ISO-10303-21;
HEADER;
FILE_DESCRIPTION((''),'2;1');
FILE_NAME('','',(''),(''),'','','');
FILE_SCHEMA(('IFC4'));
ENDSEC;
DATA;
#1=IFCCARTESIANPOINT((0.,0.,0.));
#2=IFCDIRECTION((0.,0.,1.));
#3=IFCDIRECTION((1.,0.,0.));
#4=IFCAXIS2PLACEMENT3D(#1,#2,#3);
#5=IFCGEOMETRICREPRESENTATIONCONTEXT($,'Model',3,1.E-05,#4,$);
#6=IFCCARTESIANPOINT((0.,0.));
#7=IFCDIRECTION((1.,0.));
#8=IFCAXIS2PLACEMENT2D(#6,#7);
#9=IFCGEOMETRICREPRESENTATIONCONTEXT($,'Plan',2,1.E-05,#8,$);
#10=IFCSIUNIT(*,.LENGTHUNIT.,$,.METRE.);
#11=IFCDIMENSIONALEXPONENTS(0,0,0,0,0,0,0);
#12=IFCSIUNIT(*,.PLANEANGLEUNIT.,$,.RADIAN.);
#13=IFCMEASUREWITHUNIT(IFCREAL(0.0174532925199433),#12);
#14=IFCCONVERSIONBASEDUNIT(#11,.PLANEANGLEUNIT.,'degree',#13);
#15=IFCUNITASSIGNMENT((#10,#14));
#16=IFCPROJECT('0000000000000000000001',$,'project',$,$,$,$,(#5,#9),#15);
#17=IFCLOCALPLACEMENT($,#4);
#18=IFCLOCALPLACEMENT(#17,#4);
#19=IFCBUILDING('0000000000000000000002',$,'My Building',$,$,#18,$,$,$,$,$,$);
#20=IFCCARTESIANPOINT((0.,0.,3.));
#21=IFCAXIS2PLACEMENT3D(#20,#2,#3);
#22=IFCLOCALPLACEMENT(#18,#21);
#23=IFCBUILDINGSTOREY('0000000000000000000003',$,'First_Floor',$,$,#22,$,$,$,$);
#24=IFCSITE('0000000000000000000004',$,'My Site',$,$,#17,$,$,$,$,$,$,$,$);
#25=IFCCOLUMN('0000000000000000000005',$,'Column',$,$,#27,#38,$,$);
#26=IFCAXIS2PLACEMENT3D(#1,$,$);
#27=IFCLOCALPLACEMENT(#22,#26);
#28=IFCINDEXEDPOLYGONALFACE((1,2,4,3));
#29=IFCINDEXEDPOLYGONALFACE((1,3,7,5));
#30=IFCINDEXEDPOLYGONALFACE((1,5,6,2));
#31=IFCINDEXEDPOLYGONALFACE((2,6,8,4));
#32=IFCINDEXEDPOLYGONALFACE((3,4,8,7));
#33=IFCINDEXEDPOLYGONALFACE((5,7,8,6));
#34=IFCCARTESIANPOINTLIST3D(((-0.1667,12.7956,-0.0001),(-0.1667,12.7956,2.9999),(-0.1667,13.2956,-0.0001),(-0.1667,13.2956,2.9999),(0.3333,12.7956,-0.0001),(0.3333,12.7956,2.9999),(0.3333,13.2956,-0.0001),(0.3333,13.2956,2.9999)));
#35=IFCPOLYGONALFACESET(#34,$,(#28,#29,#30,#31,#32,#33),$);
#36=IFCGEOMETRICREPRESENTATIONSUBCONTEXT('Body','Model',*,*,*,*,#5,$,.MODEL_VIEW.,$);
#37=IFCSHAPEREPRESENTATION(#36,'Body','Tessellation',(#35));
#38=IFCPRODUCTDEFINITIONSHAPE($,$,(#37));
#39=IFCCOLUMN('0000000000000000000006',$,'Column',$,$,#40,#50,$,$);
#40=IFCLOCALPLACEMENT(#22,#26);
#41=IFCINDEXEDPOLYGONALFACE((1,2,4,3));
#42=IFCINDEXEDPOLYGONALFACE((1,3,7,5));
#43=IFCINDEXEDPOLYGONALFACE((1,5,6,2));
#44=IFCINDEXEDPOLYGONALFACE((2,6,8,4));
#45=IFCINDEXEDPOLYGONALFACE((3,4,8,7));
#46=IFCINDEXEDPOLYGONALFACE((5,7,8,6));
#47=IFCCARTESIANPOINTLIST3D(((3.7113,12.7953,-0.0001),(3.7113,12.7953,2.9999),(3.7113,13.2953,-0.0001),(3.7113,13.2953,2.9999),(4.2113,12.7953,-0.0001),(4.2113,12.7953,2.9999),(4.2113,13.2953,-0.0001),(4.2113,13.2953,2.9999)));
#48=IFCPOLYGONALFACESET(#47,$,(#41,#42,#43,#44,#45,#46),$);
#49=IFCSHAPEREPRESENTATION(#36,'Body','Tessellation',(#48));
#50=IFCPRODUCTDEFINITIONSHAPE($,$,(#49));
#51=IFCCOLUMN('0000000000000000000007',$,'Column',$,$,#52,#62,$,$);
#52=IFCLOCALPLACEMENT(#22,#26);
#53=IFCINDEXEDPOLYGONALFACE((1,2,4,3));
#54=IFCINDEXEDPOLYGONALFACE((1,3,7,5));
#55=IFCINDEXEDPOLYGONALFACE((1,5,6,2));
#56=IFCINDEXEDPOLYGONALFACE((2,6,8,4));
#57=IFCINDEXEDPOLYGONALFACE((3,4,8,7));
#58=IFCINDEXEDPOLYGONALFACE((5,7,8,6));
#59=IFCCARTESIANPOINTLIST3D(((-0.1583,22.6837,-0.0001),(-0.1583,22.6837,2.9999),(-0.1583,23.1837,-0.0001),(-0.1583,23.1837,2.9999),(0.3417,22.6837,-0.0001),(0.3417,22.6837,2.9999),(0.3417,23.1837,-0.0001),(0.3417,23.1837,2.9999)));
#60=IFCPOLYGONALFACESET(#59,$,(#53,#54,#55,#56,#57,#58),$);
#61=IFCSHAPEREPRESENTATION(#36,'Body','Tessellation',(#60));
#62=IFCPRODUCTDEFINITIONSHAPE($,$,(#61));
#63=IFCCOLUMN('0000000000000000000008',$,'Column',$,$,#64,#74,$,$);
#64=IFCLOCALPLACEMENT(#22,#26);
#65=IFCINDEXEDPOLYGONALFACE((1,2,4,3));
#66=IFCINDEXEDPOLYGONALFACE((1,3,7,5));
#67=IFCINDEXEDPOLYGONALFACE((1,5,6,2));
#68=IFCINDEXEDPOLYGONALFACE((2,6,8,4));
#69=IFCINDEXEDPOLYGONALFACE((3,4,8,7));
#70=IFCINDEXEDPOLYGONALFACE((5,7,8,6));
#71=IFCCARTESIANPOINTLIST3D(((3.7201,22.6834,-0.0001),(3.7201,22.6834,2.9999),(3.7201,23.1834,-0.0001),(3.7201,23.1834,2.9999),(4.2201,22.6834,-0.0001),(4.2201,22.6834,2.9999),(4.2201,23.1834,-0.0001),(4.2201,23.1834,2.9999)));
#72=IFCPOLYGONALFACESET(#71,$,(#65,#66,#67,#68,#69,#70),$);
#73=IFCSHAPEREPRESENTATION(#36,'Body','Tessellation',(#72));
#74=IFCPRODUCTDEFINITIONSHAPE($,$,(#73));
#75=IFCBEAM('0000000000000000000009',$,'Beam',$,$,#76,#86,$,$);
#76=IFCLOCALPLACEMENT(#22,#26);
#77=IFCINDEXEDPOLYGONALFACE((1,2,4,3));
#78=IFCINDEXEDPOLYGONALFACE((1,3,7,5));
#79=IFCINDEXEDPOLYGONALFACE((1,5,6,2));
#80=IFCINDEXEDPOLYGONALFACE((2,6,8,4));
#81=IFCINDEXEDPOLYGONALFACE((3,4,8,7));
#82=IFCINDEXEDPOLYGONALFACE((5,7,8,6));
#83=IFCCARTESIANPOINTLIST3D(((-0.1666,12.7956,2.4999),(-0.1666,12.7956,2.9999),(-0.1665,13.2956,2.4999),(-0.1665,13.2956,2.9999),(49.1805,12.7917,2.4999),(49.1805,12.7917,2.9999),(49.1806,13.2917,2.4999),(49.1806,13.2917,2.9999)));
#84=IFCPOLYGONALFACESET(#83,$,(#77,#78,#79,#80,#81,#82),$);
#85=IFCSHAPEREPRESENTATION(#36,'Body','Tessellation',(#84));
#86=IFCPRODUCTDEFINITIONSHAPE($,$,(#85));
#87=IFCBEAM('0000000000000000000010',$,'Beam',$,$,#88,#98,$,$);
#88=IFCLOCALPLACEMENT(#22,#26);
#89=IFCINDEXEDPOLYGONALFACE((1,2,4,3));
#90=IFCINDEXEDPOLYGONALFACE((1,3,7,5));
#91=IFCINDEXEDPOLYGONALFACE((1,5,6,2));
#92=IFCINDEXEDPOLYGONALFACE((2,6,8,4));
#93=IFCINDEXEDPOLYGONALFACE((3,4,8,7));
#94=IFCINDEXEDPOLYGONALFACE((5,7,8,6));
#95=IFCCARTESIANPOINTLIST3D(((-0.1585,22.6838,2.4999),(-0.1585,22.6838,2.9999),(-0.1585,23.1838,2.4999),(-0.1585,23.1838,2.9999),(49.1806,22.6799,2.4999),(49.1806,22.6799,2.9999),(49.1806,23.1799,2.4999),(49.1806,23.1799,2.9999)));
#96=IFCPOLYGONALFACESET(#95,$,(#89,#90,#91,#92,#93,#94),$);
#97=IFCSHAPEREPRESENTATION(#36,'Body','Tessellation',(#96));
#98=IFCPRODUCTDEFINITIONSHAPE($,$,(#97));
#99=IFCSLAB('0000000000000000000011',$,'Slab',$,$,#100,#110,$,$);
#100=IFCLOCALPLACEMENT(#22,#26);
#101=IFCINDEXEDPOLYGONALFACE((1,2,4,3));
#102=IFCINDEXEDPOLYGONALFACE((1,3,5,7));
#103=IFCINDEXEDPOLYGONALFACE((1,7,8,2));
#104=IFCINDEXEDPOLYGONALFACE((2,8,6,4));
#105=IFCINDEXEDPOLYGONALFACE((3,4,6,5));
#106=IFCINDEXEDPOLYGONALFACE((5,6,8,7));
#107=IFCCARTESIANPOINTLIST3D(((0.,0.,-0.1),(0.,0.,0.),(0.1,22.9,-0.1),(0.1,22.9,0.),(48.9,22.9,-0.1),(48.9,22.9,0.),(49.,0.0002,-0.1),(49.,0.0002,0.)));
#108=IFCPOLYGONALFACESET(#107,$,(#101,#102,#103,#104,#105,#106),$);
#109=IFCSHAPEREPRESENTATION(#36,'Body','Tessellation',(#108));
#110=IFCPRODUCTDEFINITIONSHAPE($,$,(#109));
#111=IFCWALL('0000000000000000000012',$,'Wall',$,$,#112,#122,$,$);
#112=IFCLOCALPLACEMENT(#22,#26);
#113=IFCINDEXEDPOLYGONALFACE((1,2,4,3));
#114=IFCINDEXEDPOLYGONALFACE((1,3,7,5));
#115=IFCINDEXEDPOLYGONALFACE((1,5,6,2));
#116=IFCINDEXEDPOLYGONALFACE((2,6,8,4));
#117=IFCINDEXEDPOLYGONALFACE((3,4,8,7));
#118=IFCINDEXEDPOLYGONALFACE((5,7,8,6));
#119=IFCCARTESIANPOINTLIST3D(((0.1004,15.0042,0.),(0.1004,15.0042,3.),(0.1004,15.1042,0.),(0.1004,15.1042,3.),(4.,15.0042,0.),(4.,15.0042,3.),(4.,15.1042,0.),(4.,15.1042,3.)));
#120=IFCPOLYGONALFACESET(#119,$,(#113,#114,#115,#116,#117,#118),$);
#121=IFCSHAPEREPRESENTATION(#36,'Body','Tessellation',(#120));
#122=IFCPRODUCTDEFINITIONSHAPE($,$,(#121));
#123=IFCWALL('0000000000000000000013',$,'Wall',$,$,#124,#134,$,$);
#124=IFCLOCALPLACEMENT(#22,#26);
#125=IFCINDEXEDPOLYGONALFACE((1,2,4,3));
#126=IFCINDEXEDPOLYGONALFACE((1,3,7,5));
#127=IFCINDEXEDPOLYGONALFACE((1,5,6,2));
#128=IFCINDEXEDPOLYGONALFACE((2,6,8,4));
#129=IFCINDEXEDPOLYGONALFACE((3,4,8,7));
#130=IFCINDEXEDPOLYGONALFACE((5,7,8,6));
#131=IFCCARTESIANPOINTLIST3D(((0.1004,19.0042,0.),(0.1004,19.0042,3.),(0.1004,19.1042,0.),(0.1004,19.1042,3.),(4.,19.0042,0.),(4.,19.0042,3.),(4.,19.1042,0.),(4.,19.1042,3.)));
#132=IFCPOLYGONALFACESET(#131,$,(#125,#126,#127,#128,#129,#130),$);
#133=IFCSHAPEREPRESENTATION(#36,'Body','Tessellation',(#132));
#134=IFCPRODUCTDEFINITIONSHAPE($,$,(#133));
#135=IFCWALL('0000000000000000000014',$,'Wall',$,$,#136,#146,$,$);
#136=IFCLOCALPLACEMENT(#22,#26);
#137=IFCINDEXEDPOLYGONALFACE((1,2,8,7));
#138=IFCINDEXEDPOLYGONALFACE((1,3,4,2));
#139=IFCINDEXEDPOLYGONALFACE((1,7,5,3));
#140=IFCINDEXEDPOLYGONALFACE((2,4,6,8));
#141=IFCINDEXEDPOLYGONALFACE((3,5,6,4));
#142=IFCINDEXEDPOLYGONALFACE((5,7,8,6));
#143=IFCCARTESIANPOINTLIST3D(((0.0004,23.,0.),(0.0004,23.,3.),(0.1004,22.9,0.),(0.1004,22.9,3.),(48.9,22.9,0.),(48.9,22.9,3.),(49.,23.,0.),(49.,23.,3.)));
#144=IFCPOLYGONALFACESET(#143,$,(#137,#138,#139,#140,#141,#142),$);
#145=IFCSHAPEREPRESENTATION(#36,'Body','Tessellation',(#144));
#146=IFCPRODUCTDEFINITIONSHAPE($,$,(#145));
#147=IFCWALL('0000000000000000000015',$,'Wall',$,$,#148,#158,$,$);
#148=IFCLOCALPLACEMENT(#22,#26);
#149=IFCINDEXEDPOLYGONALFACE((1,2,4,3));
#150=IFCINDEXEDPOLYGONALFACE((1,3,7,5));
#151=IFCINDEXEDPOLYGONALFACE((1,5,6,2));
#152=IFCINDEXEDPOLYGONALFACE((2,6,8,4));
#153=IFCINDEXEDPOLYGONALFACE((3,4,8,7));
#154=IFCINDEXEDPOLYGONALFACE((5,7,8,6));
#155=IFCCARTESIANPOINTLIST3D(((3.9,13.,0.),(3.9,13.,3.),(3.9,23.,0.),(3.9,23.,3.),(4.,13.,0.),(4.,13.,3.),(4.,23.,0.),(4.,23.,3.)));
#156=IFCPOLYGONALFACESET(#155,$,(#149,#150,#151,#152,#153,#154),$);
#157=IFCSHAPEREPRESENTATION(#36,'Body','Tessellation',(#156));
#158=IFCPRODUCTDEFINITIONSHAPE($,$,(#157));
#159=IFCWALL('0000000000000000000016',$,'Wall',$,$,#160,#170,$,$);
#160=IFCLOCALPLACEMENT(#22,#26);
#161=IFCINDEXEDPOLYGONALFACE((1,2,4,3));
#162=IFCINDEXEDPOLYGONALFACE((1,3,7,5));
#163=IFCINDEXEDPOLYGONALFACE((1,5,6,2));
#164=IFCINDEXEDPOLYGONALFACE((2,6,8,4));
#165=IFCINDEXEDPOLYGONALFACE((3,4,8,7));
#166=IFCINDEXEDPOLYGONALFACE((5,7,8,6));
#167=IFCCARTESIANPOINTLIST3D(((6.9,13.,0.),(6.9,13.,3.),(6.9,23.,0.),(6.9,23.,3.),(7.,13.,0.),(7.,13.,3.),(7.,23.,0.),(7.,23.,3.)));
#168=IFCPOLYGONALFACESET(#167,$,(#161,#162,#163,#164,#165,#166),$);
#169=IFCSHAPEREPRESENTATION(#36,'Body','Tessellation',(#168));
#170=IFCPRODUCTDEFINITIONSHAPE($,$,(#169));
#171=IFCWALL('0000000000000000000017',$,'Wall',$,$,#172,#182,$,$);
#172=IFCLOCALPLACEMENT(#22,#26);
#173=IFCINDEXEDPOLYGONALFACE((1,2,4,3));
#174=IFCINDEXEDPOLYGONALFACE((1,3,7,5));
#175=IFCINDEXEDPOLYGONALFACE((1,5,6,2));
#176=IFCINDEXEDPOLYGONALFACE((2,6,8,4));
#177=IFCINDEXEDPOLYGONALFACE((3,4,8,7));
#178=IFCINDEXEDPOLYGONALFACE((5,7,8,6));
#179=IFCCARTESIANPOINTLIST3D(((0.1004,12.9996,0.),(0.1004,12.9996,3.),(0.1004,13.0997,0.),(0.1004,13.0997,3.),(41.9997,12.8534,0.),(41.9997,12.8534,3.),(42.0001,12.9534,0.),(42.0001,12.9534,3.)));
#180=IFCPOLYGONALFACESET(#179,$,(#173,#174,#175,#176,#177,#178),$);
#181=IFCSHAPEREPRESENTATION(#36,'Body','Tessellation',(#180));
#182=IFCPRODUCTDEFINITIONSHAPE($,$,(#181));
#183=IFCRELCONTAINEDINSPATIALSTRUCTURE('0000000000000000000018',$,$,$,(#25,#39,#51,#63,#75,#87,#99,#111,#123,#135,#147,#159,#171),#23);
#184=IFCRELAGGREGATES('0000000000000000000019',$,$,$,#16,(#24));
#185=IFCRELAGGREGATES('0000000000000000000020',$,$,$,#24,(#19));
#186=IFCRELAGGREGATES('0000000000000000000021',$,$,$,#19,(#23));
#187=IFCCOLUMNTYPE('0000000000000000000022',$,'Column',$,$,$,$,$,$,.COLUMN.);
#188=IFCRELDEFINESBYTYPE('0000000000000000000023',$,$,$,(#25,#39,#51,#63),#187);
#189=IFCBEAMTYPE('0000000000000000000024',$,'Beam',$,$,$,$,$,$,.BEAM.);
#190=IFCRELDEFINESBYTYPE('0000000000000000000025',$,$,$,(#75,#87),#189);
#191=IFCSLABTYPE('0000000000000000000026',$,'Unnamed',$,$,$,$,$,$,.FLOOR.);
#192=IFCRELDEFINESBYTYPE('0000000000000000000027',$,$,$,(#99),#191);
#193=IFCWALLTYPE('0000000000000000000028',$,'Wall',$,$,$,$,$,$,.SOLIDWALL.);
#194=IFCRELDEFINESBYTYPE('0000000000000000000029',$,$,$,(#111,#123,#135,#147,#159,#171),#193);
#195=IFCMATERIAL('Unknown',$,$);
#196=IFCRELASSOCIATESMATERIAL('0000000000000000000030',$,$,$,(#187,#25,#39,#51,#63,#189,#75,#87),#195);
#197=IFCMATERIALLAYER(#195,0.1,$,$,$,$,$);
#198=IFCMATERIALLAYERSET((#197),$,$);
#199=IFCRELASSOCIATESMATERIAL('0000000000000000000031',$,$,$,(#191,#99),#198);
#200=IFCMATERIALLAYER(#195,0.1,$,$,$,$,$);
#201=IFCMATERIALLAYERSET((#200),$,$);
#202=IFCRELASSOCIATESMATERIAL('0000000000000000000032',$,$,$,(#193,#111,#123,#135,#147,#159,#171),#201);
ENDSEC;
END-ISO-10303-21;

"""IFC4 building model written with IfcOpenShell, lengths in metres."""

from ifc_helpers import new_model, entity, si_unit, converted_unit, frame, origin_with_axes, origin_2d_with_axis, place, context, subcontext, project, spatial, line, indexed_curve, rectangle, outline, extrude, material, layer, layer_set, layer_usage, material_profile, profile_set, profile_usage, type_object, element, save


model = new_model("IFC4")

# Units and contexts
model_context = context("Model", 3, precision=1e-05, world=origin_with_axes())
plan_context = context("Plan", 2, precision=1e-05, world=origin_2d_with_axis())
body_context = subcontext(model_context, "Body", "Model", "MODEL_VIEW")
ifc_project = project(units=[si_unit("LENGTHUNIT", "METRE"), converted_unit("PLANEANGLEUNIT", "degree", entity("IfcReal", 0.0174532925199433), si_unit("PLANEANGLEUNIT", "RADIAN"), dimensions=[0, 0, 0, 0, 0, 0, 0])], contexts=[model_context, plan_context])

# Site, building, storey
site_placement = place(None, origin_with_axes())
site = spatial("IfcSite", under=ifc_project, at=site_placement, Name="My Site")
building_placement = place(site_placement, origin_with_axes())
building = spatial("IfcBuilding", under=site, at=building_placement, Name="My Building")
storey_placement = place(building_placement, frame((0.0, 0.0, 3.0), z_axis=(0.0, 0.0, 1.0), x_axis=(1.0, 0.0, 0.0)))
storey = spatial("IfcBuildingStorey", under=building, at=storey_placement, Name="First_Floor")

# Columns
ifc_material = material(Name="Unknown")
ifc_material_profile_1 = material_profile(ifc_material, rectangle(XDim=0.5, YDim=0.5))
ifc_profile_set_1 = profile_set([ifc_material_profile_1])
ifc_profile_usage_1 = profile_usage(ifc_profile_set_1, cardinal=5)
column_type = type_object("IfcColumnType", Name="Column", PredefinedType="COLUMN", material=ifc_profile_set_1)
column_1_placement = place(storey_placement, frame((0.0833, 13.0456, -0.0001), z_axis=(0.0, 0.0, 1.0), x_axis=(1.0, 0.0, 0.0)))
element("IfcColumn", 1, at=column_1_placement, inside=storey, type_object=column_type, material=ifc_profile_usage_1, Name="Column", context=body_context, shape_type="SweptSolid", body=[
    extrude(rectangle(XDim=0.5, YDim=0.5), origin_with_axes(), (0.0, 0.0, 1.0), 3.0),
])
ifc_profile_usage_2 = profile_usage(ifc_profile_set_1, cardinal=5)
column_2_placement = place(storey_placement, frame((3.9613, 13.0453, -0.0001), z_axis=(0.0, 0.0, 1.0), x_axis=(1.0, 0.0, 0.0)))
element("IfcColumn", 2, at=column_2_placement, inside=storey, type_object=column_type, material=ifc_profile_usage_2, Name="Column", context=body_context, shape_type="SweptSolid", body=[
    extrude(rectangle(XDim=0.5, YDim=0.5), origin_with_axes(), (0.0, 0.0, 1.0), 3.0),
])
ifc_profile_usage_3 = profile_usage(ifc_profile_set_1, cardinal=5)
column_3_placement = place(storey_placement, frame((0.0917, 22.9337, -0.0001), z_axis=(0.0, 0.0, 1.0), x_axis=(1.0, 0.0, 0.0)))
element("IfcColumn", 3, at=column_3_placement, inside=storey, type_object=column_type, material=ifc_profile_usage_3, Name="Column", context=body_context, shape_type="SweptSolid", body=[
    extrude(rectangle(XDim=0.5, YDim=0.5), origin_with_axes(), (0.0, 0.0, 1.0), 3.0),
])
ifc_profile_usage_4 = profile_usage(ifc_profile_set_1, cardinal=5)
column_4_placement = place(storey_placement, frame((3.9701, 22.9334, -0.0001), z_axis=(0.0, 0.0, 1.0), x_axis=(1.0, 0.0, 0.0)))
element("IfcColumn", 4, at=column_4_placement, inside=storey, type_object=column_type, material=ifc_profile_usage_4, Name="Column", context=body_context, shape_type="SweptSolid", body=[
    extrude(rectangle(XDim=0.5, YDim=0.5), origin_with_axes(), (0.0, 0.0, 1.0), 3.0),
])

# Beams
ifc_material_profile_2 = material_profile(ifc_material, rectangle(XDim=0.5, YDim=0.5))
ifc_profile_set_2 = profile_set([ifc_material_profile_2])
ifc_profile_usage_5 = profile_usage(ifc_profile_set_2, cardinal=5)
beam_type = type_object("IfcBeamType", Name="Beam", PredefinedType="BEAM", material=ifc_profile_set_2)
beam_1_placement = place(storey_placement, frame((-0.1666, 13.0456, 2.7499), z_axis=(1.0, -0.000079, 0.0), x_axis=(0.000079, 1.0, 0.0)))
element("IfcBeam", 5, at=beam_1_placement, inside=storey, type_object=beam_type, material=ifc_profile_usage_5, Name="Beam", context=body_context, shape_type="SweptSolid", body=[
    extrude(rectangle(XDim=0.5, YDim=0.5), origin_with_axes(), (0.0, 0.0, 1.0), 49.3471),
])
ifc_profile_usage_6 = profile_usage(ifc_profile_set_2, cardinal=5)
beam_2_placement = place(storey_placement, frame((-0.1585, 22.9338, 2.7499), z_axis=(1.0, -0.000079, 0.0), x_axis=(0.000079, 1.0, 0.0)))
element("IfcBeam", 6, at=beam_2_placement, inside=storey, type_object=beam_type, material=ifc_profile_usage_6, Name="Beam", context=body_context, shape_type="SweptSolid", body=[
    extrude(rectangle(XDim=0.5, YDim=0.5), origin_with_axes(), (0.0, 0.0, 1.0), 49.3391),
])

# Slab
ifc_layer_1 = layer(ifc_material, 0.1)
ifc_layer_set_1 = layer_set([ifc_layer_1])
ifc_layer_usage_1 = layer_usage(ifc_layer_set_1, "AXIS3", "POSITIVE", -0.1)
slab_type = type_object("IfcSlabType", Name="Unnamed", PredefinedType="FLOOR", material=ifc_layer_set_1)
slab_placement = place(storey_placement, frame((0.1, 22.9, 0.0), z_axis=(0.0, 0.0, 1.0), x_axis=(1.0, 0.0, 0.0)))
element("IfcSlab", 7, at=slab_placement, inside=storey, type_object=slab_type, material=ifc_layer_usage_1, Name="Slab", context=body_context, shape_type="SweptSolid", body=[
    extrude(outline(indexed_curve([(0.0, 0.0), (48.8, 0.0), (48.9, -22.8998), (-0.1, -22.9), (0.0, 0.0)])), frame((0.0, 0.0, -0.1), z_axis=(0.0, 0.0, 1.0), x_axis=(1.0, 0.0, 0.0)), (0.0, 0.0, 1.0), 0.1),
])

# Walls
ifc_layer_2 = layer(ifc_material, 0.1)
ifc_layer_set_2 = layer_set([ifc_layer_2])
ifc_layer_usage_2 = layer_usage(ifc_layer_set_2, "AXIS2", "POSITIVE", 0.0)
wall_type = type_object("IfcWallType", Name="Wall", PredefinedType="SOLIDWALL", material=ifc_layer_set_2)
wall_1_placement = place(storey_placement, frame((0.1004, 15.0042, 0.0), z_axis=(0.0, 0.0, 1.0), x_axis=(1.0, 0.0, 0.0)))
element("IfcWall", 8, at=wall_1_placement, inside=storey, type_object=wall_type, material=ifc_layer_usage_2, Name="Wall", context=body_context, shape_type="SweptSolid", body=[
    extrude(outline(indexed_curve([(0.0, 0.0), (0.0, 0.1), (3.8996, 0.1), (3.8996, 0.0)], segments=[line(1, 2, 3, 4, 1)])), origin_with_axes(), (0.0, 0.0, 1.0), 3.0),
])
ifc_layer_usage_3 = layer_usage(ifc_layer_set_2, "AXIS2", "POSITIVE", 0.0)
wall_2_placement = place(storey_placement, frame((0.1004, 19.0042, 0.0), z_axis=(0.0, 0.0, 1.0), x_axis=(1.0, 0.0, 0.0)))
element("IfcWall", 9, at=wall_2_placement, inside=storey, type_object=wall_type, material=ifc_layer_usage_3, Name="Wall", context=body_context, shape_type="SweptSolid", body=[
    extrude(outline(indexed_curve([(0.0, 0.0), (0.0, 0.1), (3.8996, 0.1), (3.8996, 0.0)], segments=[line(1, 2, 3, 4, 1)])), origin_with_axes(), (0.0, 0.0, 1.0), 3.0),
])
ifc_layer_usage_4 = layer_usage(ifc_layer_set_2, "AXIS2", "POSITIVE", 0.0)
wall_3_placement = place(storey_placement, frame((0.1004, 22.9, 0.0), z_axis=(0.0, 0.0, 1.0), x_axis=(1.0, 0.0, 0.0)))
element("IfcWall", 10, at=wall_3_placement, inside=storey, type_object=wall_type, material=ifc_layer_usage_4, Name="Wall", context=body_context, shape_type="SweptSolid", body=[
    extrude(outline(indexed_curve([(0.0, 0.0), (-0.1, 0.1), (48.8996, 0.1), (48.7996, 0.0)], segments=[line(1, 2, 3, 4, 1)])), origin_with_axes(), (0.0, 0.0, 1.0), 3.0),
])
ifc_layer_usage_5 = layer_usage(ifc_layer_set_2, "AXIS2", "POSITIVE", 0.0)
wall_4_placement = place(storey_placement, frame((3.9, 23.0, 0.0), z_axis=(0.0, 0.0, 1.0), x_axis=(0.0, -1.0, 0.0)))
element("IfcWall", 11, at=wall_4_placement, inside=storey, type_object=wall_type, material=ifc_layer_usage_5, Name="Wall", context=body_context, shape_type="SweptSolid", body=[
    extrude(outline(indexed_curve([(0.0, 0.0), (0.0, 0.1), (10.0, 0.1), (10.0, 0.0)], segments=[line(1, 2, 3, 4, 1)])), origin_with_axes(), (0.0, 0.0, 1.0), 3.0),
])
ifc_layer_usage_6 = layer_usage(ifc_layer_set_2, "AXIS2", "POSITIVE", 0.0)
wall_5_placement = place(storey_placement, frame((6.9, 23.0, 0.0), z_axis=(0.0, 0.0, 1.0), x_axis=(0.0, -1.0, 0.0)))
element("IfcWall", 12, at=wall_5_placement, inside=storey, type_object=wall_type, material=ifc_layer_usage_6, Name="Wall", context=body_context, shape_type="SweptSolid", body=[
    extrude(outline(indexed_curve([(0.0, 0.0), (0.0, 0.1), (10.0, 0.1), (10.0, 0.0)], segments=[line(1, 2, 3, 4, 1)])), origin_with_axes(), (0.0, 0.0, 1.0), 3.0),
])
ifc_layer_usage_7 = layer_usage(ifc_layer_set_2, "AXIS2", "POSITIVE", 0.0)
wall_6_placement = place(storey_placement, frame((0.1004, 12.9996, 0.0), z_axis=(0.0, 0.0, 1.0), x_axis=(0.999994, -0.003491, 0.0)))
element("IfcWall", 13, at=wall_6_placement, inside=storey, type_object=wall_type, material=ifc_layer_usage_7, Name="Wall", context=body_context, shape_type="SweptSolid", body=[
    extrude(outline(indexed_curve([(0.0, 0.0), (-0.0003, 0.1), (41.8996, 0.1), (41.8996, 0.0)], segments=[line(1, 2, 3, 4, 1)])), origin_with_axes(), (0.0, 0.0, 1.0), 3.0),
])

save(model, "model.ifc")
